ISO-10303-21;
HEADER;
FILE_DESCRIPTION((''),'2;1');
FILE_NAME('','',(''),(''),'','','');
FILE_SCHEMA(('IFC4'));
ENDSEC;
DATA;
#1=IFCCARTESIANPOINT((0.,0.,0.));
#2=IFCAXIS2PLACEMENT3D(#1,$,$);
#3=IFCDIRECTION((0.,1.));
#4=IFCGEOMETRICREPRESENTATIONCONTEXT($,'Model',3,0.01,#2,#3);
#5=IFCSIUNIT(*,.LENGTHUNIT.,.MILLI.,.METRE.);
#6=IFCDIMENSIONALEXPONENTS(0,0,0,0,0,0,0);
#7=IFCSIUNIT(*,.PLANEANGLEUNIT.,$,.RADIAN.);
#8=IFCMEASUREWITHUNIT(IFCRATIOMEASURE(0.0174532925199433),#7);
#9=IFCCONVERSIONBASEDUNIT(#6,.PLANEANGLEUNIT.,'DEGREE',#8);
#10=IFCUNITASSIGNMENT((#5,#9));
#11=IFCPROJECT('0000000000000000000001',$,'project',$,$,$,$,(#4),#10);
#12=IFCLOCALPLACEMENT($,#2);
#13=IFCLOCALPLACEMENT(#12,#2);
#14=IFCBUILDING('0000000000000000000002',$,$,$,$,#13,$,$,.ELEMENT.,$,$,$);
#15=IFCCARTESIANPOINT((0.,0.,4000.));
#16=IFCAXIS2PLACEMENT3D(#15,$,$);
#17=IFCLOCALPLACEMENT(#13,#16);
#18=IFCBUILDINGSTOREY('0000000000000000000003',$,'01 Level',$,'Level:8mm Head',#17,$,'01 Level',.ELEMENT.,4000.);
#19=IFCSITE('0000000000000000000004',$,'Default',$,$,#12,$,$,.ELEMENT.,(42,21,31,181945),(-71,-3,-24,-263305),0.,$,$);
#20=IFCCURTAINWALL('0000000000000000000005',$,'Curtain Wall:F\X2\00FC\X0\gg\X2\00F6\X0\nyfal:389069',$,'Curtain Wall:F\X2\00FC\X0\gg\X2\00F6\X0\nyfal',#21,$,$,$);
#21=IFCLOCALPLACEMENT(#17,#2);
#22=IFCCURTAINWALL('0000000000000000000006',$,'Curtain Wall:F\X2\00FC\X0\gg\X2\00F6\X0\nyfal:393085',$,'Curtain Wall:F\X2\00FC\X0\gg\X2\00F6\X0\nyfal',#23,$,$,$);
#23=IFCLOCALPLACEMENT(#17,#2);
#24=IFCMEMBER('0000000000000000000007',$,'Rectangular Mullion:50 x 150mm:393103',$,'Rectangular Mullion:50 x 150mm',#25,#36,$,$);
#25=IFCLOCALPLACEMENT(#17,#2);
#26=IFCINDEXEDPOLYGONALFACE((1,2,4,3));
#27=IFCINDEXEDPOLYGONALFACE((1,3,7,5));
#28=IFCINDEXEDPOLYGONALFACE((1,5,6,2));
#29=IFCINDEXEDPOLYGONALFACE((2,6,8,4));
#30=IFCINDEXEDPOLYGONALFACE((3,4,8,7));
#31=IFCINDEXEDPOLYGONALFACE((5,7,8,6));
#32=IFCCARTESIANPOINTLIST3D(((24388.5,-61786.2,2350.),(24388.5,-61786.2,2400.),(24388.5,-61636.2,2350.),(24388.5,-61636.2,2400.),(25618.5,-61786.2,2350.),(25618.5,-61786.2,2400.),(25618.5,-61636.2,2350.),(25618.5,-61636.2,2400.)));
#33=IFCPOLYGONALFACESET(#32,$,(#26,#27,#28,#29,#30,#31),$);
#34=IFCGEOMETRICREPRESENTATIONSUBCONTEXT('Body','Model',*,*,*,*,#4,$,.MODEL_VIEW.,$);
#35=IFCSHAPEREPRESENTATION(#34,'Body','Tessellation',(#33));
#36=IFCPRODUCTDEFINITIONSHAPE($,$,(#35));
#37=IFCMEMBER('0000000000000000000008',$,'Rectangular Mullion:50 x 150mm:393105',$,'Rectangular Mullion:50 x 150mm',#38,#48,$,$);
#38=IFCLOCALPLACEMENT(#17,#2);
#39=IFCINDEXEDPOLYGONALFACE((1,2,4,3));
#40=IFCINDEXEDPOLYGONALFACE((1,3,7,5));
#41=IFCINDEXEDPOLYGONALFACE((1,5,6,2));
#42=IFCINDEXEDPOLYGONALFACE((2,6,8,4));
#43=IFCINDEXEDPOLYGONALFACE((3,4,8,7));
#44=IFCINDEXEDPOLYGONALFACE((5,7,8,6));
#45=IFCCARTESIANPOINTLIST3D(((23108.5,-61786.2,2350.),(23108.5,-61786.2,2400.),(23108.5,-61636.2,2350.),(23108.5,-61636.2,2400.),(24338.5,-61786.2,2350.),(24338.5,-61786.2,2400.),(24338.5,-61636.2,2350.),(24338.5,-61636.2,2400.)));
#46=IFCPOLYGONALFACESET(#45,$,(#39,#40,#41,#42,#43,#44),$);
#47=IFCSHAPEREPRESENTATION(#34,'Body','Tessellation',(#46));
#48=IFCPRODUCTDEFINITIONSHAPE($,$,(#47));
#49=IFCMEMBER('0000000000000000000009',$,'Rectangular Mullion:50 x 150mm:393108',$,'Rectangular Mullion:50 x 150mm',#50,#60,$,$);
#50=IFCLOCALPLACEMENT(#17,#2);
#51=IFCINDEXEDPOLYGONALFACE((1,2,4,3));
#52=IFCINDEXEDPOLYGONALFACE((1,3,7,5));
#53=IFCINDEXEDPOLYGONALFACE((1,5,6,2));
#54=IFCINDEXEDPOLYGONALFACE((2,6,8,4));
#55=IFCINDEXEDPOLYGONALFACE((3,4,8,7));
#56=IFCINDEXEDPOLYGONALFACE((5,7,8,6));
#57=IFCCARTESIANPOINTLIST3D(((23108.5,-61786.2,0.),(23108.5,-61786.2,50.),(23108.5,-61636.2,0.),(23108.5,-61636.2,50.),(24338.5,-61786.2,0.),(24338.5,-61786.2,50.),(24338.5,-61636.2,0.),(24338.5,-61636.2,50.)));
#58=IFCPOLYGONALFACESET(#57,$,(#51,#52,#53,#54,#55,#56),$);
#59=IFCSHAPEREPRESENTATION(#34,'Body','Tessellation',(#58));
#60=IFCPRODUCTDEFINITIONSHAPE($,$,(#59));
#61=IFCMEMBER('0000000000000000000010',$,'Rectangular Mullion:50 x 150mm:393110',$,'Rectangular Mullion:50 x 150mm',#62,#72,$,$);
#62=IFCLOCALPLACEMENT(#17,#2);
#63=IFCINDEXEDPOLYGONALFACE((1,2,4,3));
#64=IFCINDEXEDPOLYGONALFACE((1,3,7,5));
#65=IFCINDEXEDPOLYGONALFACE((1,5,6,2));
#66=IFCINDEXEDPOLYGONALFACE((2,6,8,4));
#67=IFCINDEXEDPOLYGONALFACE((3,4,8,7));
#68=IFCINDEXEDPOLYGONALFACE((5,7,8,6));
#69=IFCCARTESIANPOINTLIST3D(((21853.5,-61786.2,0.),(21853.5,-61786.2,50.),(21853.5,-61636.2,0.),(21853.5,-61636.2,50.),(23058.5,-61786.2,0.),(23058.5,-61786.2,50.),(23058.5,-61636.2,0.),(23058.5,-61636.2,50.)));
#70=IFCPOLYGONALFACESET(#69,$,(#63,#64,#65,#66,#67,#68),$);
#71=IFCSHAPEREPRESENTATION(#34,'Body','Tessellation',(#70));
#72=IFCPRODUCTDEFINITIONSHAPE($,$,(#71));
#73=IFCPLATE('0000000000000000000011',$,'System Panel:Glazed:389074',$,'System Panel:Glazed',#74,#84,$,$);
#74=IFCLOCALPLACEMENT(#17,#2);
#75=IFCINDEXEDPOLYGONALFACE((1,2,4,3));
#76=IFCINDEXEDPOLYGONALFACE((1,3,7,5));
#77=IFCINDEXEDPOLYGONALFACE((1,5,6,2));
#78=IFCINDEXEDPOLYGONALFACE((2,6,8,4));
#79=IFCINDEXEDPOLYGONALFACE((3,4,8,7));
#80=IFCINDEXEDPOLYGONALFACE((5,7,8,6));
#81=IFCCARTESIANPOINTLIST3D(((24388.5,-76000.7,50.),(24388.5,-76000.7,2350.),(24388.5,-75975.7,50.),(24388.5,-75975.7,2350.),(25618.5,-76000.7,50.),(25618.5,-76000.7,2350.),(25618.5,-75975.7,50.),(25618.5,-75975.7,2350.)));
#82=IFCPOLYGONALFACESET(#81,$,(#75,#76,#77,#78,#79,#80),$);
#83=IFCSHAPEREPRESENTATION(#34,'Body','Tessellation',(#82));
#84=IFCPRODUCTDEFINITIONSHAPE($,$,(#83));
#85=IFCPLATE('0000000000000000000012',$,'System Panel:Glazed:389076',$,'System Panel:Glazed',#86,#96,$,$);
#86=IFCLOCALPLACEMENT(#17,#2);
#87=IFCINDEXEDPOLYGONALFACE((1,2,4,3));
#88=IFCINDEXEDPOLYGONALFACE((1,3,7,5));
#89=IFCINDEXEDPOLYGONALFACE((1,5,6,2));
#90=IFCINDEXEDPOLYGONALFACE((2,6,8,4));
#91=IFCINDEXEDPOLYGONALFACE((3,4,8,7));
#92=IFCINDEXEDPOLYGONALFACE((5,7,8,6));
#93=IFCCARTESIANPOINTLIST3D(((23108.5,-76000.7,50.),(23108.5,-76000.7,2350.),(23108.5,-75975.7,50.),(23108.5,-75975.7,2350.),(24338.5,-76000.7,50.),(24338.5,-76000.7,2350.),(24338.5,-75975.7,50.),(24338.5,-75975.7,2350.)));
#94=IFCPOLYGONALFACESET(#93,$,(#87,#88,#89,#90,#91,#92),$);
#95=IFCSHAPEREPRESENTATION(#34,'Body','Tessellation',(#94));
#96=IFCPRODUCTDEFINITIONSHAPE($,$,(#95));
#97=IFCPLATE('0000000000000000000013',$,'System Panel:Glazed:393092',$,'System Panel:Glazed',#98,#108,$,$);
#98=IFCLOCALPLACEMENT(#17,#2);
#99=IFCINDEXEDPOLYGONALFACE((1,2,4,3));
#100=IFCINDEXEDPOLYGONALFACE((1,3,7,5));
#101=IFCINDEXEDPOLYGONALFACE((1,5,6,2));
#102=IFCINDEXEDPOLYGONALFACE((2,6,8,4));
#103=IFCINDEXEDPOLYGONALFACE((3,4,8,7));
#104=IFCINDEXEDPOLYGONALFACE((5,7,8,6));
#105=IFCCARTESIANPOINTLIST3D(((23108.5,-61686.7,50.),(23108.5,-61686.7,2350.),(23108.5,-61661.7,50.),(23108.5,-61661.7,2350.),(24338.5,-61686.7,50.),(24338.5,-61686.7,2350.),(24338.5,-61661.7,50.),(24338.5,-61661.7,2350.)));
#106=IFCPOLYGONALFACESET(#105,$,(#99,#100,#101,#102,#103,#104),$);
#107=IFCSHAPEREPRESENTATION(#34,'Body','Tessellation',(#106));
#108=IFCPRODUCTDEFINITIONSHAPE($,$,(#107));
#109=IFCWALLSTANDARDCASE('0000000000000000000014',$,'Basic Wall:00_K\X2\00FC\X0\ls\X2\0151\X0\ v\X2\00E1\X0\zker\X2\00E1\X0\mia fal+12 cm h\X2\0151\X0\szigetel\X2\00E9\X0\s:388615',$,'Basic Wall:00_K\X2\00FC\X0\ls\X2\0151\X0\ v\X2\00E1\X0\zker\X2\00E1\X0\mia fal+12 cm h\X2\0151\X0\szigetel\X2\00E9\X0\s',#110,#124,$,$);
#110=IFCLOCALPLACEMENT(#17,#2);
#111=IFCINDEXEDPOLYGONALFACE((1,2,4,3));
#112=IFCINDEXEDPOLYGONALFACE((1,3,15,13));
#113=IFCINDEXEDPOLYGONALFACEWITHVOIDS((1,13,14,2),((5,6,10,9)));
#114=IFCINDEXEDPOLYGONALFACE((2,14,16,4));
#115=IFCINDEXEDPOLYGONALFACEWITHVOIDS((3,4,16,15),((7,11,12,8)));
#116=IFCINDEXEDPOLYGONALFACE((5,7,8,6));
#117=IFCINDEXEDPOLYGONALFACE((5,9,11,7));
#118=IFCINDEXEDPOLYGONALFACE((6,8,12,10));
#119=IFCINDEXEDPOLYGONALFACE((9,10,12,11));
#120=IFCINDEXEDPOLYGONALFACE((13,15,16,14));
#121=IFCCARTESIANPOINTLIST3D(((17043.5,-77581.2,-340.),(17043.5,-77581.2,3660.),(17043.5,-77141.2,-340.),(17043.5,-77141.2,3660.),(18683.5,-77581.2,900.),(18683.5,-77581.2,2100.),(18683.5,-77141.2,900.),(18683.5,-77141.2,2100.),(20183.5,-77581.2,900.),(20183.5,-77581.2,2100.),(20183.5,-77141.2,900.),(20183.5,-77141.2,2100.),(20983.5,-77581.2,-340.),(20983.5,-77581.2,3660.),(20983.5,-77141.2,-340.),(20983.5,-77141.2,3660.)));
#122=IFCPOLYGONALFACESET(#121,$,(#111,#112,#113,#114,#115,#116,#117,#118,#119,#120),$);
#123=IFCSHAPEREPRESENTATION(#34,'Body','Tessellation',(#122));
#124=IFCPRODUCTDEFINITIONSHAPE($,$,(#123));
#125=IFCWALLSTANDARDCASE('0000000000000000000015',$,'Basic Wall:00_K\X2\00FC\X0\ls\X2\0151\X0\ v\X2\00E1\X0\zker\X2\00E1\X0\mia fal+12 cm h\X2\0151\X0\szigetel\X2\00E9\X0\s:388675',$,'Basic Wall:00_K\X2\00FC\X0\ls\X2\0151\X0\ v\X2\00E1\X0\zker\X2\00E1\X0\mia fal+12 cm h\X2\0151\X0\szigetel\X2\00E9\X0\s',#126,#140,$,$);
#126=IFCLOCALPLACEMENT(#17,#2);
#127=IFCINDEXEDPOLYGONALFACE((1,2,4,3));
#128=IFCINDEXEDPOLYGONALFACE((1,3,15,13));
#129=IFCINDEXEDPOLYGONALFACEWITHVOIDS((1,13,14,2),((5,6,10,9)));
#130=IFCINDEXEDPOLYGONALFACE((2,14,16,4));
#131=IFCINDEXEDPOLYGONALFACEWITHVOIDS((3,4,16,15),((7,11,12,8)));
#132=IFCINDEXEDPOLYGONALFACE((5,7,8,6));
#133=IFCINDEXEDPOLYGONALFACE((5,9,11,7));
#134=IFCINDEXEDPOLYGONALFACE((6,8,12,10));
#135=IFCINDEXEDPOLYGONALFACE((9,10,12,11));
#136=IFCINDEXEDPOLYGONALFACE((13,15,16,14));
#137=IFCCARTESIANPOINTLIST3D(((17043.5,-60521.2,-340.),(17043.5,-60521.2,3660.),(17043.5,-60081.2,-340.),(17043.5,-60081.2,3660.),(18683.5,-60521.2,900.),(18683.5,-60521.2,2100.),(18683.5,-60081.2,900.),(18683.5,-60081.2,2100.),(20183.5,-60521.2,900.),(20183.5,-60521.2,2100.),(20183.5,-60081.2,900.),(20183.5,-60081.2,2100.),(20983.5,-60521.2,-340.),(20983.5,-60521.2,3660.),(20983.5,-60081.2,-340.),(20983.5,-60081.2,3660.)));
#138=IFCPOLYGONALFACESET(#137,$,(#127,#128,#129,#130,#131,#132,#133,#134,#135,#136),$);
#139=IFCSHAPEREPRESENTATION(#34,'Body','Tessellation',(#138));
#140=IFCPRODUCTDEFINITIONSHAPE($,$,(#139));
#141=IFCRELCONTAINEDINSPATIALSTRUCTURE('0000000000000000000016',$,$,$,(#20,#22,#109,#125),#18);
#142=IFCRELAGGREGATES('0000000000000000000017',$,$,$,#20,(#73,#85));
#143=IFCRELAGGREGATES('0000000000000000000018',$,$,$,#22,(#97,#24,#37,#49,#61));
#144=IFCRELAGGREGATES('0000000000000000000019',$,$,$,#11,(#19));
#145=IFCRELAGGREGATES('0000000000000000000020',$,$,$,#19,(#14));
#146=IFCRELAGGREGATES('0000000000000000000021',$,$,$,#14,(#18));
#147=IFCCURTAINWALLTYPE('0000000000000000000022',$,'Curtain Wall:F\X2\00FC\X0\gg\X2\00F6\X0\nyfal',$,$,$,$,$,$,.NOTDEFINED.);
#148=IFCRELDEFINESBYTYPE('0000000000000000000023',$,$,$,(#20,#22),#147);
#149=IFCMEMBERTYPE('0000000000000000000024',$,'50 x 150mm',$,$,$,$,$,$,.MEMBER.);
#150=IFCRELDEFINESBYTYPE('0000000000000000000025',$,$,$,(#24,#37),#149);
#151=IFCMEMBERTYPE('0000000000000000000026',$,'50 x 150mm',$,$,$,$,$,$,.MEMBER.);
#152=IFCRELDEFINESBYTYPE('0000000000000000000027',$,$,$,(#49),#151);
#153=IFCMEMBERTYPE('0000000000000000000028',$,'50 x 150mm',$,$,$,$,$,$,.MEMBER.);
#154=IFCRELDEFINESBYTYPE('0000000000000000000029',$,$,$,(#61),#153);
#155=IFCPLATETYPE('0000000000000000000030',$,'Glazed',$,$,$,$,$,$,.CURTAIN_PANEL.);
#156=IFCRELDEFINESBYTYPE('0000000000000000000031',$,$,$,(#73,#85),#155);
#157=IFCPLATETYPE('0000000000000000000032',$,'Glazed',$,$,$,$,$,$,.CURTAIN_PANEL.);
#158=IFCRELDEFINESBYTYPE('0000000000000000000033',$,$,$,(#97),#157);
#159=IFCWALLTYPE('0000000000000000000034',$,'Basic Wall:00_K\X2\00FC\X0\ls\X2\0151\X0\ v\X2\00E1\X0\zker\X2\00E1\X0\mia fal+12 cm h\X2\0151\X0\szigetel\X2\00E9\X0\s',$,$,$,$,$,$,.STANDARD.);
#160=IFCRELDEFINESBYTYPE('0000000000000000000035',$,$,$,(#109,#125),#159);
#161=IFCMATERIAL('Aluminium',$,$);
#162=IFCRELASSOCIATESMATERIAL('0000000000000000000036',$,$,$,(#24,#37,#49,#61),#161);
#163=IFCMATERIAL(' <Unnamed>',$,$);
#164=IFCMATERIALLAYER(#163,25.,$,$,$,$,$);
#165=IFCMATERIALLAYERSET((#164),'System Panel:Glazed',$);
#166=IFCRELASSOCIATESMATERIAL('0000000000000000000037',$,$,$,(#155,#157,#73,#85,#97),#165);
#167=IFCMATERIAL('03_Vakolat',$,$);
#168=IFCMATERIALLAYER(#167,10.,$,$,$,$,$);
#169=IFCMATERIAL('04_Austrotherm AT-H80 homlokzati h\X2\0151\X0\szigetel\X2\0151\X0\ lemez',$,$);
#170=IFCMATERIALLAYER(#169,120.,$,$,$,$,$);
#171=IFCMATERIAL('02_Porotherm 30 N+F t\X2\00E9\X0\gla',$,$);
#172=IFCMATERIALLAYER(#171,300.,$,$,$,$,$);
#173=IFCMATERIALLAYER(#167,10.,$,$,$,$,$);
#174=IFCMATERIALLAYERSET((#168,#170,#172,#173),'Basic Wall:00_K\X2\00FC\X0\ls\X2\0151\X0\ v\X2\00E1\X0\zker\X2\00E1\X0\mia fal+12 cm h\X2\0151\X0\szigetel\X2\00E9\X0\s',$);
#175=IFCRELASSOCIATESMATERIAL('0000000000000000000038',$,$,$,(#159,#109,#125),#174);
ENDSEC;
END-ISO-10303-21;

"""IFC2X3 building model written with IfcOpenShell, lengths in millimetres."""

from ifc_helpers import new_model, entity, si_unit, converted_unit, direction, frame, frame_2d, origin, origin_2d_with_axis, place, context, subcontext, project, spatial, rectangle, extrude, source, transform, mapped, material, layer, layer_set, layer_usage, type_object, type_shapes, element, aggregate, save


model = new_model("IFC2X3")

# Units and contexts
model_context = context("Model", 3, precision=0.01, world=origin(), true_north=direction((0.0, 1.0)))
body_context = subcontext(model_context, "Body", "Model", "MODEL_VIEW")
ifc_project = project(units=[si_unit("LENGTHUNIT", "METRE", prefix="MILLI"), converted_unit("PLANEANGLEUNIT", "DEGREE", entity("IfcRatioMeasure", 0.0174532925199433), si_unit("PLANEANGLEUNIT", "RADIAN"), dimensions=[0, 0, 0, 0, 0, 0, 0])], contexts=[model_context])

# Site, building, storey
site_placement = place(None, origin())
site = spatial("IfcSite", under=ifc_project, at=site_placement, Name="Default", CompositionType="ELEMENT", RefLatitude=(42, 21, 31, 181945), RefLongitude=(-71, -3, -24, -263305), RefElevation=0.0)
building_placement = place(site_placement, origin())
building = spatial("IfcBuilding", under=site, at=building_placement, CompositionType="ELEMENT")
storey_placement = place(building_placement, frame((0.0, 0.0, 4000.0)))
storey = spatial("IfcBuildingStorey", under=building, at=storey_placement, Name="01 Level", ObjectType="Level:8mm Head", LongName="01 Level", CompositionType="ELEMENT", Elevation=4000.0)

# Curtain walls, members
curtain_wall_type = type_object("IfcCurtainWallType", Name="Curtain Wall:Függönyfal", PredefinedType="NOTDEFINED")
curtain_wall_1_placement = place(storey_placement, frame((0.0, 0.0, -4000.0)))
curtain_wall_1 = element("IfcCurtainWall", 1, at=curtain_wall_1_placement, inside=storey, type_object=curtain_wall_type, Name="Curtain Wall:Függönyfal:389069", ObjectType="Curtain Wall:Függönyfal")
ifc_material_1 = material(Name="Aluminium")
curtain_wall_2_placement = place(storey_placement, frame((0.0, 0.0, -4000.0)))
curtain_wall_2 = element("IfcCurtainWall", 2, at=curtain_wall_2_placement, inside=storey, type_object=curtain_wall_type, Name="Curtain Wall:Függönyfal:393085", ObjectType="Curtain Wall:Függönyfal")
member_type_1 = type_object("IfcMemberType", Name="50 x 150mm", PredefinedType="MEMBER")
shared_shape_1 = source(origin(), body_context, "Body", "SweptSolid", [
    extrude(rectangle(XDim=150.0, YDim=50.0, at=origin_2d_with_axis()), frame((-25.0, 0.0, -1230.0), z_axis=(0.0, 0.0, 1.0), x_axis=(0.0, -1.0, 0.0)), (0.0, 0.0, 1.0), 1230.0),
])
type_shapes(member_type_1, [shared_shape_1])
member_1_placement = place(storey_placement, frame((24388.5, -61711.2, 2400.0), z_axis=(-1.0, 0.0, 0.0), x_axis=(0.0, 0.0, 1.0)))
member_1 = element("IfcMember", 3, at=member_1_placement, type_object=member_type_1, material=ifc_material_1, Name="Rectangular Mullion:50 x 150mm:393103", ObjectType="Rectangular Mullion:50 x 150mm", context=body_context, shape_type="MappedRepresentation", body=[
    mapped(shared_shape_1, transform((0.0, 0.0, 0.0), scale=1.0)),
])
member_2_placement = place(storey_placement, frame((23108.5, -61711.2, 2400.0), z_axis=(-1.0, 0.0, 0.0), x_axis=(0.0, 0.0, 1.0)))
member_2 = element("IfcMember", 4, at=member_2_placement, type_object=member_type_1, material=ifc_material_1, Name="Rectangular Mullion:50 x 150mm:393105", ObjectType="Rectangular Mullion:50 x 150mm", context=body_context, shape_type="MappedRepresentation", body=[
    mapped(shared_shape_1, transform((0.0, 0.0, 0.0), scale=1.0)),
])
member_type_2 = type_object("IfcMemberType", Name="50 x 150mm", PredefinedType="MEMBER")
shared_shape_2 = source(origin(), body_context, "Body", "SweptSolid", [
    extrude(rectangle(XDim=150.0, YDim=50.0, at=origin_2d_with_axis()), frame((-25.0, 0.0, -1230.0), z_axis=(0.0, 0.0, 1.0), x_axis=(0.0, -1.0, 0.0)), (0.0, 0.0, 1.0), 1230.0),
])
type_shapes(member_type_2, [shared_shape_2])
member_3_placement = place(storey_placement, frame((24338.5, -61711.2, 0.0), z_axis=(1.0, 0.0, 0.0), x_axis=(0.0, 0.0, -1.0)))
member_3 = element("IfcMember", 5, at=member_3_placement, type_object=member_type_2, material=ifc_material_1, Name="Rectangular Mullion:50 x 150mm:393108", ObjectType="Rectangular Mullion:50 x 150mm", context=body_context, shape_type="MappedRepresentation", body=[
    mapped(shared_shape_2, transform((0.0, 0.0, 0.0), scale=1.0)),
])
member_type_3 = type_object("IfcMemberType", Name="50 x 150mm", PredefinedType="MEMBER")
shared_shape_3 = source(origin(), body_context, "Body", "SweptSolid", [
    extrude(rectangle(XDim=150.0, YDim=50.0, at=origin_2d_with_axis()), frame((-25.0, 0.0, -1205.0), z_axis=(0.0, 0.0, 1.0), x_axis=(0.0, -1.0, 0.0)), (0.0, 0.0, 1.0), 1205.0),
])
type_shapes(member_type_3, [shared_shape_3])
member_4_placement = place(storey_placement, frame((23058.5, -61711.2, 0.0), z_axis=(1.0, 0.0, 0.0), x_axis=(0.0, 0.0, -1.0)))
member_4 = element("IfcMember", 6, at=member_4_placement, type_object=member_type_3, material=ifc_material_1, Name="Rectangular Mullion:50 x 150mm:393110", ObjectType="Rectangular Mullion:50 x 150mm", context=body_context, shape_type="MappedRepresentation", body=[
    mapped(shared_shape_3, transform((0.0, 0.0, 0.0), scale=1.0)),
])

# Plates
ifc_material_2 = material(Name=" <Unnamed>")
ifc_layer_1 = layer(ifc_material_2, 25.0)
ifc_layer_set_1 = layer_set([ifc_layer_1], Name="System Panel:Glazed")
ifc_layer_usage_1 = layer_usage(ifc_layer_set_1, "AXIS3", "POSITIVE", 0.1)
plate_type_1 = type_object("IfcPlateType", Name="Glazed", PredefinedType="CURTAIN_PANEL", material=ifc_layer_set_1)
shared_shape_4 = source(origin(), body_context, "Body", "SweptSolid", [
    extrude(rectangle(XDim=25.0, YDim=1230.0, at=origin_2d_with_axis()), frame((615.0, 12.5, 0.0), z_axis=(0.0, 0.0, 1.0), x_axis=(0.0, 1.0, 0.0)), (0.0, 0.0, 1.0), 2300.0),
])
type_shapes(plate_type_1, [shared_shape_4])
plate_1_placement = place(curtain_wall_1_placement, frame((25618.5, -75975.7, 4050.0), z_axis=(0.0, 0.0, 1.0), x_axis=(-1.0, 0.0, 0.0)))
plate_1 = element("IfcPlate", 7, at=plate_1_placement, type_object=plate_type_1, material=ifc_layer_usage_1, Name="System Panel:Glazed:389074", ObjectType="System Panel:Glazed", context=body_context, shape_type="MappedRepresentation", body=[
    mapped(shared_shape_4, transform((0.0, 0.0, 0.0), scale=1.0)),
])
ifc_layer_usage_2 = layer_usage(ifc_layer_set_1, "AXIS3", "POSITIVE", 0.1)
plate_2_placement = place(curtain_wall_1_placement, frame((24338.5, -75975.7, 4050.0), z_axis=(0.0, 0.0, 1.0), x_axis=(-1.0, 0.0, 0.0)))
plate_2 = element("IfcPlate", 8, at=plate_2_placement, type_object=plate_type_1, material=ifc_layer_usage_2, Name="System Panel:Glazed:389076", ObjectType="System Panel:Glazed", context=body_context, shape_type="MappedRepresentation", body=[
    mapped(shared_shape_4, transform((0.0, 0.0, 0.0), scale=1.0)),
])
ifc_layer_usage_3 = layer_usage(ifc_layer_set_1, "AXIS3", "POSITIVE", 0.1)
plate_type_2 = type_object("IfcPlateType", Name="Glazed", PredefinedType="CURTAIN_PANEL", material=ifc_layer_set_1)
shared_shape_5 = source(origin(), body_context, "Body", "SweptSolid", [
    extrude(rectangle(XDim=25.0, YDim=1230.0, at=frame_2d((0.0, 0.0), x_axis=(1.0, 0.0))), frame((615.0, 12.5, 0.0), z_axis=(0.0, 0.0, 1.0), x_axis=(0.0, 1.0, 0.0)), (0.0, 0.0, 1.0), 2300.0),
])
type_shapes(plate_type_2, [shared_shape_5])
plate_3_placement = place(curtain_wall_2_placement, frame((24338.5, -61661.7, 4050.0), z_axis=(0.0, 0.0, 1.0), x_axis=(-1.0, 0.0, 0.0)))
plate_3 = element("IfcPlate", 9, at=plate_3_placement, type_object=plate_type_2, material=ifc_layer_usage_3, Name="System Panel:Glazed:393092", ObjectType="System Panel:Glazed", context=body_context, shape_type="MappedRepresentation", body=[
    mapped(shared_shape_5, transform((0.0, 0.0, 0.0), scale=1.0)),
])

# Walls, openings
ifc_material_3 = material(Name="03_Vakolat")
ifc_layer_2 = layer(ifc_material_3, 10.0)
ifc_material_4 = material(Name="04_Austrotherm AT-H80 homlokzati hőszigetelő lemez")
ifc_layer_3 = layer(ifc_material_4, 120.0)
ifc_material_5 = material(Name="02_Porotherm 30 N+F tégla")
ifc_layer_4 = layer(ifc_material_5, 300.0)
ifc_layer_5 = layer(ifc_material_3, 10.0)
ifc_layer_set_2 = layer_set([ifc_layer_2, ifc_layer_3, ifc_layer_4, ifc_layer_5], Name="Basic Wall:00_Külső vázkerámia fal+12 cm hőszigetelés")
ifc_layer_usage_4 = layer_usage(ifc_layer_set_2, "AXIS2", "NEGATIVE", 220.0)
wall_type_1 = type_object("IfcWallType", Name="Basic Wall:00_Külső vázkerámia fal+12 cm hőszigetelés", PredefinedType="STANDARD", material=ifc_layer_set_2)
wall_1_placement = place(storey_placement, frame((20983.5, -77361.2, -340.0), z_axis=(0.0, 0.0, 1.0), x_axis=(-1.0, 0.0, 0.0)))
wall_1 = element("IfcWallStandardCase", 10, at=wall_1_placement, inside=storey, type_object=wall_type_1, material=ifc_layer_usage_4, Name="Basic Wall:00_Külső vázkerámia fal+12 cm hőszigetelés:388615", ObjectType="Basic Wall:00_Külső vázkerámia fal+12 cm hőszigetelés", context=body_context, shape_type="SweptSolid", body=[
    extrude(rectangle(XDim=3940.0, YDim=440.0, at=frame_2d((1970.0, 0.0), x_axis=(-1.0, 0.0))), origin(), (0.0, 0.0, 1.0), 4000.0),
])
opening_1_placement = place(wall_1_placement, frame((2300.0, 1744.0, 1240.0), z_axis=(0.0, 0.0, 1.0), x_axis=(-1.0, 0.0, 0.0)))
element("IfcOpeningElement", 11, at=opening_1_placement, cuts=wall_1, ObjectType="Opening", context=body_context, shape_type="SweptSolid", body=[
    extrude(rectangle(XDim=1200.0, YDim=1500.0, at=frame_2d((0.0, 0.0), x_axis=(0.0, 1.0))), frame((750.0, 3048.0, 600.0), z_axis=(0.0, -1.0, 0.0), x_axis=(1.0, 0.0, 0.0)), (0.0, 0.0, 1.0), 3048.0),
])
ifc_layer_usage_5 = layer_usage(ifc_layer_set_2, "AXIS2", "POSITIVE", -220.0)
wall_2_placement = place(storey_placement, frame((20983.5, -60301.2, -340.0), z_axis=(0.0, 0.0, 1.0), x_axis=(-1.0, 0.0, 0.0)))
wall_2 = element("IfcWallStandardCase", 12, at=wall_2_placement, inside=storey, type_object=wall_type_1, material=ifc_layer_usage_5, Name="Basic Wall:00_Külső vázkerámia fal+12 cm hőszigetelés:388675", ObjectType="Basic Wall:00_Külső vázkerámia fal+12 cm hőszigetelés", context=body_context, shape_type="SweptSolid", body=[
    extrude(rectangle(XDim=3940.0, YDim=440.0, at=frame_2d((1970.0, 0.0), x_axis=(-1.0, 0.0))), origin(), (0.0, 0.0, 1.0), 4000.0),
])
opening_2_placement = place(wall_2_placement, frame((2300.0, 1304.0, 1240.0), z_axis=(0.0, 0.0, 1.0), x_axis=(-1.0, 0.0, 0.0)))
element("IfcOpeningElement", 13, at=opening_2_placement, cuts=wall_2, ObjectType="Opening", context=body_context, shape_type="SweptSolid", body=[
    extrude(rectangle(XDim=1200.0, YDim=1500.0, at=frame_2d((0.0, 0.0), x_axis=(0.0, 1.0))), frame((750.0, 3048.0, 600.0), z_axis=(0.0, -1.0, 0.0), x_axis=(1.0, 0.0, 0.0)), (0.0, 0.0, 1.0), 3048.0),
])

aggregate(curtain_wall_1, [plate_1, plate_2])
aggregate(curtain_wall_2, [plate_3, member_1, member_2, member_3, member_4])

save(model, "model.ifc")
